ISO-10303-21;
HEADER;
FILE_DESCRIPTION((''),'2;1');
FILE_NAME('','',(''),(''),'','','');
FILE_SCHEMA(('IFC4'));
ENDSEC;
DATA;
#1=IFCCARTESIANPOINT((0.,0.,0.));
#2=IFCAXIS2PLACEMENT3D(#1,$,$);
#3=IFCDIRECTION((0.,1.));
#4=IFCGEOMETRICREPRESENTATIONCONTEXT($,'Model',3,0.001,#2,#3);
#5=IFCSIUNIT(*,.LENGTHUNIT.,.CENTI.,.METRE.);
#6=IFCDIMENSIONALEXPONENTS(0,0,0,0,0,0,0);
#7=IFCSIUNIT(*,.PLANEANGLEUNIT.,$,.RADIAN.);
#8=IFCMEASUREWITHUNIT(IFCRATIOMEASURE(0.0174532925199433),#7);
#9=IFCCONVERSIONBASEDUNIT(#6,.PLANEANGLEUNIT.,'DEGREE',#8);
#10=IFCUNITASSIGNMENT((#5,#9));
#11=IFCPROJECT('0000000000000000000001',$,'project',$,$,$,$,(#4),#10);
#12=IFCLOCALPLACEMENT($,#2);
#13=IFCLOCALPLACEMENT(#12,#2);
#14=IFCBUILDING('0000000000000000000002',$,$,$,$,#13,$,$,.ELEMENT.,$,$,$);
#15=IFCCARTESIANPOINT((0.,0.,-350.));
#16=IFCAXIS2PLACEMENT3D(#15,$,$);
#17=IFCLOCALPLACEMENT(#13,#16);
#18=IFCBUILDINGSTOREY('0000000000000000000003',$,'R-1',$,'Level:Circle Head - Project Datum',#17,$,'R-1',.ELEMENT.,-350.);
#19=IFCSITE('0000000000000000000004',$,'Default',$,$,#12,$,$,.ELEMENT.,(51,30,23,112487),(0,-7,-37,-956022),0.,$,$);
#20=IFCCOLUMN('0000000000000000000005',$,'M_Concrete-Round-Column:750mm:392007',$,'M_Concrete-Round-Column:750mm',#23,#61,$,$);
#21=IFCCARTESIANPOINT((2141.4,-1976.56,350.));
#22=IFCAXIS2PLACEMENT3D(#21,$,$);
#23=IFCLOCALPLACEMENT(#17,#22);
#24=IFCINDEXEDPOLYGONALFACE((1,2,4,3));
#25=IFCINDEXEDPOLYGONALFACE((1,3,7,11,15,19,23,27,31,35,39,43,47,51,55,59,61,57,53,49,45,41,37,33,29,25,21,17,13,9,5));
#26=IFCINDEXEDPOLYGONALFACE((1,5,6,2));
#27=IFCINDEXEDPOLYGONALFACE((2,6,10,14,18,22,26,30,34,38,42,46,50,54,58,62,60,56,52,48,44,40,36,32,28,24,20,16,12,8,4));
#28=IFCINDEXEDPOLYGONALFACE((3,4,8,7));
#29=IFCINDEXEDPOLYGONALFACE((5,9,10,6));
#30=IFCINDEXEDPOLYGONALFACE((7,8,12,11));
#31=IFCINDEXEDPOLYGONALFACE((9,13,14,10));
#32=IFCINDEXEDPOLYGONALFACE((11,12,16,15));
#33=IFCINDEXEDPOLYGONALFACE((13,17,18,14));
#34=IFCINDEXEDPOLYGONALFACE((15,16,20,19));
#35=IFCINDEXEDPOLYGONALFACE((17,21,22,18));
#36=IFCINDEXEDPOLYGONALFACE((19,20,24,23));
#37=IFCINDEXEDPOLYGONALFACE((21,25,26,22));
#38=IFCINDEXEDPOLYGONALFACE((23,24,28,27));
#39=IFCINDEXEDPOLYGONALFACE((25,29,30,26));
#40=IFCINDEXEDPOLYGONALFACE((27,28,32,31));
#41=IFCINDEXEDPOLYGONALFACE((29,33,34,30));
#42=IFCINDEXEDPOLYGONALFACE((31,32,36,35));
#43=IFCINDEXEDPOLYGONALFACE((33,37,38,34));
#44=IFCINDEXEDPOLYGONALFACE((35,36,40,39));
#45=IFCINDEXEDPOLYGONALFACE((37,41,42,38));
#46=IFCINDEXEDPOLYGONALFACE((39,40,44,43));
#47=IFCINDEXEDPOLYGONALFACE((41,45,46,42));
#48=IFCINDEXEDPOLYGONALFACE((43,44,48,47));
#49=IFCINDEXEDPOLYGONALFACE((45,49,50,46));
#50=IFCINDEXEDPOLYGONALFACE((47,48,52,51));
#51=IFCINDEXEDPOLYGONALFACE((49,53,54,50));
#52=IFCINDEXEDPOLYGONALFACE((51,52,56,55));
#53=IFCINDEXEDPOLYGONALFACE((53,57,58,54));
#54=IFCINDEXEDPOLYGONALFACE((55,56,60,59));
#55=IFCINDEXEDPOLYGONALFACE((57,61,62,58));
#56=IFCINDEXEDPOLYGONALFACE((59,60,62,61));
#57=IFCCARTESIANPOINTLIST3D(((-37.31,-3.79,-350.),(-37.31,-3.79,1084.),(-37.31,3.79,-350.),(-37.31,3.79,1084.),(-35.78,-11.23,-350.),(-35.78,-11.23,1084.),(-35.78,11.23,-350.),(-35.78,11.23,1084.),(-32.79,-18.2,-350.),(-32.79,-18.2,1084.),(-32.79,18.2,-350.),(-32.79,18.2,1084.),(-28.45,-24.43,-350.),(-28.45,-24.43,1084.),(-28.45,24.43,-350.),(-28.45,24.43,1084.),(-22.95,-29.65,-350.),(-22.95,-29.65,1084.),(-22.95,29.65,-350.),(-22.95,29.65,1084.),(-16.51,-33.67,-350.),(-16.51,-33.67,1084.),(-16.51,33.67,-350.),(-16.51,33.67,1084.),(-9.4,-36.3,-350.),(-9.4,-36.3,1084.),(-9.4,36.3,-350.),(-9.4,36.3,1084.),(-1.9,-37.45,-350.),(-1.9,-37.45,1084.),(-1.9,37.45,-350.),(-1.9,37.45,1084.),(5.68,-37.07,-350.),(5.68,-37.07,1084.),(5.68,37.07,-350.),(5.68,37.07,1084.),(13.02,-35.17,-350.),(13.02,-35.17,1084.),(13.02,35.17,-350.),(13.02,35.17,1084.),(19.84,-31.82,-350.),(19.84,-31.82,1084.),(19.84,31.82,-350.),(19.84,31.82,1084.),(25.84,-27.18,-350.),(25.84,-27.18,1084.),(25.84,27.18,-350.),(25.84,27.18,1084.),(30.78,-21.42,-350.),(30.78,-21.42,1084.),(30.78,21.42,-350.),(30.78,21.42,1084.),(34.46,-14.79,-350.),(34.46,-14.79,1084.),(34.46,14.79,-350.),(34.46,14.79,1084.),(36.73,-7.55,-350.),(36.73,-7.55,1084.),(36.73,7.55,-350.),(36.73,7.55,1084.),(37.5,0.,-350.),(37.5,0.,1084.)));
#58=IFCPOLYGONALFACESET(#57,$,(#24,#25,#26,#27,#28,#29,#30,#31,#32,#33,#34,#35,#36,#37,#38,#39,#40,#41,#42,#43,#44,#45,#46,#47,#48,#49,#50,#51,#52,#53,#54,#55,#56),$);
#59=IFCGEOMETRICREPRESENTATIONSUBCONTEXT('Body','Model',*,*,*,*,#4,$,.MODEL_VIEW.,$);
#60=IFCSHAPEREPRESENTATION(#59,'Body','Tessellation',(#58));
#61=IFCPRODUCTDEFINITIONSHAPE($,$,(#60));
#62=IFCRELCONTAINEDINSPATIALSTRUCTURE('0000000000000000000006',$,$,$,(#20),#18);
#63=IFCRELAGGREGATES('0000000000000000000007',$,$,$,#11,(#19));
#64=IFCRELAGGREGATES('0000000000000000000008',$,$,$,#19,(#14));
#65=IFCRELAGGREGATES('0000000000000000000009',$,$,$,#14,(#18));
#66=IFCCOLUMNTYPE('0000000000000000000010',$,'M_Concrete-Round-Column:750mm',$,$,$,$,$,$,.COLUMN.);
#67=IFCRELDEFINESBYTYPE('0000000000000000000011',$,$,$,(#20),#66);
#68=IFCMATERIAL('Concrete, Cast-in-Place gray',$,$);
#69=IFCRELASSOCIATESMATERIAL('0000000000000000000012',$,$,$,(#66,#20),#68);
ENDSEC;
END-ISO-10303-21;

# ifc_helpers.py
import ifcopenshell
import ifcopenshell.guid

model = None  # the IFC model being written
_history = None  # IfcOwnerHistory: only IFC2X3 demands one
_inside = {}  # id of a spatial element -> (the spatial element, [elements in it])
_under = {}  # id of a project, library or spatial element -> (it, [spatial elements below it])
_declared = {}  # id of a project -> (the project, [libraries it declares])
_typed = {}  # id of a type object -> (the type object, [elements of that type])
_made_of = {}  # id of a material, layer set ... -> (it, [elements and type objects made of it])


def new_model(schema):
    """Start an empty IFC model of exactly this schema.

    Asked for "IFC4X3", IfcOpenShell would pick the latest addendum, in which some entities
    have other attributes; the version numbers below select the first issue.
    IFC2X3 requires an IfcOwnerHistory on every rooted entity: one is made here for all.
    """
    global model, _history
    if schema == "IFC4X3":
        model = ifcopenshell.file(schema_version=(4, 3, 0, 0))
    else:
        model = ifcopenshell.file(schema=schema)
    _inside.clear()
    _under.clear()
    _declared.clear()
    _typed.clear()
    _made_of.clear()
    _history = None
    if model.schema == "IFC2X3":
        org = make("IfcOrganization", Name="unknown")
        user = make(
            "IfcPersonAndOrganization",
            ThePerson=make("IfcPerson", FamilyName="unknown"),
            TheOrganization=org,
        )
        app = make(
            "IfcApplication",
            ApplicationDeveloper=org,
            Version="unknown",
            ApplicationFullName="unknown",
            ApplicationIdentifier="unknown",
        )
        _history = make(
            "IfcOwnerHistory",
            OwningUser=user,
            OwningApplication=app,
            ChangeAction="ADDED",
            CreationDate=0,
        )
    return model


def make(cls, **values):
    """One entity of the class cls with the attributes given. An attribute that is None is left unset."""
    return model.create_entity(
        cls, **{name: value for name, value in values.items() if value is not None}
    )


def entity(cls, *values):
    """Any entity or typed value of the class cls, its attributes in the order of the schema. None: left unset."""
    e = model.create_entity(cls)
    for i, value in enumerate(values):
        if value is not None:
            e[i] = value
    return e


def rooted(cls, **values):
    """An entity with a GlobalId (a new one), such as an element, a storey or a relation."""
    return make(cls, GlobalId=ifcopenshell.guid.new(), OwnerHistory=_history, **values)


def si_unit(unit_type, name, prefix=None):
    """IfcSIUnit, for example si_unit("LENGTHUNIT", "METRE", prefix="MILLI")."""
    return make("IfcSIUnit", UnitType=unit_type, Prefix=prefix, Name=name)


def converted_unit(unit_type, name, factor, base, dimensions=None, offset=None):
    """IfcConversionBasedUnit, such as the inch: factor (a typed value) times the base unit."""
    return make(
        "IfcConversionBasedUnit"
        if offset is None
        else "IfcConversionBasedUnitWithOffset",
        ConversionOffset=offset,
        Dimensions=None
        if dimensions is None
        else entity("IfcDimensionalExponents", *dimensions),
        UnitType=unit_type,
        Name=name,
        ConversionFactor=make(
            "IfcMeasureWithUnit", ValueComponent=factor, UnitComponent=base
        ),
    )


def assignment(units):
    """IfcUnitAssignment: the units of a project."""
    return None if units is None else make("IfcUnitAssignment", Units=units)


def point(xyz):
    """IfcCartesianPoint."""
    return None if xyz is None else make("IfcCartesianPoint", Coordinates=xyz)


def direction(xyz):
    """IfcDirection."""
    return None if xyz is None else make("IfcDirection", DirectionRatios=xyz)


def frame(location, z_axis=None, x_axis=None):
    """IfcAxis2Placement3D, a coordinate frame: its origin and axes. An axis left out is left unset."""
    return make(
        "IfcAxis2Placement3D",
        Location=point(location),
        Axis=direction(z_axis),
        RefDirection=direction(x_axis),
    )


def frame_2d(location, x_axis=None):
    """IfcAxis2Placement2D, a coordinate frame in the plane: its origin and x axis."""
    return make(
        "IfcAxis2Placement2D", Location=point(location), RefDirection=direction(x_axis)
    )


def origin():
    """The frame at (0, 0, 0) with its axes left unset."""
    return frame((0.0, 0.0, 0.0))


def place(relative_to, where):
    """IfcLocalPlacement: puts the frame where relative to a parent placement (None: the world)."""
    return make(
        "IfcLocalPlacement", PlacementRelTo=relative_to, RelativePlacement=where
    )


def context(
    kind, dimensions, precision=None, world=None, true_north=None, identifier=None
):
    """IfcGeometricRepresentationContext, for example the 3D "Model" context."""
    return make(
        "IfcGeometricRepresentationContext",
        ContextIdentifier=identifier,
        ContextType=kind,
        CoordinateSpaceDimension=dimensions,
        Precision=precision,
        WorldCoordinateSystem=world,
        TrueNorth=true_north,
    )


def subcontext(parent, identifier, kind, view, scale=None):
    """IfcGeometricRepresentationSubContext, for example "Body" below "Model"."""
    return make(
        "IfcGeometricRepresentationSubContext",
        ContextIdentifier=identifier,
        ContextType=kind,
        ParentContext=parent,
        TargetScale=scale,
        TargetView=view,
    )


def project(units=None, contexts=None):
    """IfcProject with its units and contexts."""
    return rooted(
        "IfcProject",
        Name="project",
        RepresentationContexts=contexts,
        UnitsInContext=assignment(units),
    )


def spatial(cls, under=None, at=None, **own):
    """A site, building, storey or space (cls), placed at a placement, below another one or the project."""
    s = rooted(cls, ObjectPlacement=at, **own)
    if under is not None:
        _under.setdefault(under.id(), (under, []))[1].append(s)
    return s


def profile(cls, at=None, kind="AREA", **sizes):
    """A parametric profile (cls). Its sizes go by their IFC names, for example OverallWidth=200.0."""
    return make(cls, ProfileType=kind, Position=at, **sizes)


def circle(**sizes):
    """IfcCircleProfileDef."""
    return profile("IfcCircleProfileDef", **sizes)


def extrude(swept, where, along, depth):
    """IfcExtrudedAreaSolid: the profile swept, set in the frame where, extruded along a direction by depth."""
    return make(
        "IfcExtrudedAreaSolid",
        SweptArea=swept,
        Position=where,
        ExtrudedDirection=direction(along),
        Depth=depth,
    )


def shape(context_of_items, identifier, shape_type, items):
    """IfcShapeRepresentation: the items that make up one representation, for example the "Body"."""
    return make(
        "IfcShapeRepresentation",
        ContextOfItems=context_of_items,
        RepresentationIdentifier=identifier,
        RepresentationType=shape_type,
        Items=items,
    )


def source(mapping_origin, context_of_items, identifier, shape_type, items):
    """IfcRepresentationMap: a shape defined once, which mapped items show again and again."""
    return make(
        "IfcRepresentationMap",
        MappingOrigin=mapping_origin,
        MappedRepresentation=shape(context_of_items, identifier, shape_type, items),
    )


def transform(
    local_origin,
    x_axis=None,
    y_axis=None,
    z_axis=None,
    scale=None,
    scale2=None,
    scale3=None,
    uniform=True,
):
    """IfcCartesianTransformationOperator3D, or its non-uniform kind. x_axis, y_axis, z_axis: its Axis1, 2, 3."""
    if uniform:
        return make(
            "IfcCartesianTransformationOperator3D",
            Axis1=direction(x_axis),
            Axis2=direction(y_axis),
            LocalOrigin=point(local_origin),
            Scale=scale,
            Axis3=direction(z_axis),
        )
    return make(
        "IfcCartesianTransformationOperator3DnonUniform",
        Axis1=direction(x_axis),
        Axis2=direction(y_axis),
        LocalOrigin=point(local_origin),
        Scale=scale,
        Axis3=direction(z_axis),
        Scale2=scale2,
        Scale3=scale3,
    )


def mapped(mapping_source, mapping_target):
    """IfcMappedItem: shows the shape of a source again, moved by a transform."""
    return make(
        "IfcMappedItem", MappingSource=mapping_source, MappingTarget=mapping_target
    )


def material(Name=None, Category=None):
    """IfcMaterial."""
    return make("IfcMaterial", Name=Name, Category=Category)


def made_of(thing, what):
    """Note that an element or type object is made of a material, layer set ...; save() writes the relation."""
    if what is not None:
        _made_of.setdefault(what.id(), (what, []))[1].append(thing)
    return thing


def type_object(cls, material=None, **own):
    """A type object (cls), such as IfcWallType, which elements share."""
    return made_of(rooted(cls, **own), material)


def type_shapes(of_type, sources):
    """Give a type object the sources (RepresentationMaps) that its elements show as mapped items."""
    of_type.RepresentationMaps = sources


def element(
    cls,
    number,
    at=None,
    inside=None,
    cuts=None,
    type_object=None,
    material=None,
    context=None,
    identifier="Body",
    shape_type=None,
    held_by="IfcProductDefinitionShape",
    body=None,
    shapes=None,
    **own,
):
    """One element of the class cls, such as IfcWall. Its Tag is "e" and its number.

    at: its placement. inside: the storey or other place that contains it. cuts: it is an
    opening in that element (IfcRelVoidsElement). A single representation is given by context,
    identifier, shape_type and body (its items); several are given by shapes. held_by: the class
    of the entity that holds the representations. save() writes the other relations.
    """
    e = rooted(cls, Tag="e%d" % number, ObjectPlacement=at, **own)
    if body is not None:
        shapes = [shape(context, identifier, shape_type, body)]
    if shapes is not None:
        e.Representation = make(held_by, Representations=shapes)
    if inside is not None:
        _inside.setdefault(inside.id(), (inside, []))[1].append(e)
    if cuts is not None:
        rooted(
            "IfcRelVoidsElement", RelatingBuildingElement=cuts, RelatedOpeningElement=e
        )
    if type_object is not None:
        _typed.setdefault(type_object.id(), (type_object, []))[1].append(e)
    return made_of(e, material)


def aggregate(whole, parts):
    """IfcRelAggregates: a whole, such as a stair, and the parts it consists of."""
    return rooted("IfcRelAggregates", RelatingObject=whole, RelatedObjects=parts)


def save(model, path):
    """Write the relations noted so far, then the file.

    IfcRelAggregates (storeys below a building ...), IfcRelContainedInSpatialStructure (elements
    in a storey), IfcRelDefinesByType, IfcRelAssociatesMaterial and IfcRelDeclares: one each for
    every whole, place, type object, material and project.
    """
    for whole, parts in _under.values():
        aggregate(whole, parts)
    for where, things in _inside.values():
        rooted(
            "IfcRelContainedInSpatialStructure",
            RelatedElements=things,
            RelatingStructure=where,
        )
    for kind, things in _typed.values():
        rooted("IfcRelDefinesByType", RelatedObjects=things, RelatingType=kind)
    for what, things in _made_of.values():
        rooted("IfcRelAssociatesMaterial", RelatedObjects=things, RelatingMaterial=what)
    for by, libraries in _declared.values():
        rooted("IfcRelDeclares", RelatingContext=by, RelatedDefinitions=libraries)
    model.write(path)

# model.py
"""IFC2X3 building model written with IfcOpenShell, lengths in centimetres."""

from ifc_helpers import new_model, entity, si_unit, converted_unit, direction, frame, frame_2d, origin, place, context, subcontext, project, spatial, circle, extrude, source, transform, mapped, material, type_object, type_shapes, element, save


model = new_model("IFC2X3")

# Units and contexts
model_context = context("Model", 3, precision=0.001, world=origin(), true_north=direction((0.0, 1.0)))
body_context = subcontext(model_context, "Body", "Model", "MODEL_VIEW")
ifc_project = project(units=[si_unit("LENGTHUNIT", "METRE", prefix="CENTI"), converted_unit("PLANEANGLEUNIT", "DEGREE", entity("IfcRatioMeasure", 0.0174532925199433), si_unit("PLANEANGLEUNIT", "RADIAN"), dimensions=[0, 0, 0, 0, 0, 0, 0])], contexts=[model_context])

# Site, building, storey
site_placement = place(None, origin())
site = spatial("IfcSite", under=ifc_project, at=site_placement, Name="Default", CompositionType="ELEMENT", RefLatitude=(51, 30, 23, 112487), RefLongitude=(0, -7, -37, -956022), RefElevation=0.0)
building_placement = place(site_placement, origin())
building = spatial("IfcBuilding", under=site, at=building_placement, CompositionType="ELEMENT")
storey_placement = place(building_placement, frame((0.0, 0.0, -350.0)))
storey = spatial("IfcBuildingStorey", under=building, at=storey_placement, Name="R-1", ObjectType="Level:Circle Head - Project Datum", LongName="R-1", CompositionType="ELEMENT", Elevation=-350.0)

# Column
ifc_material_1 = material(Name="Concrete, Cast-in-Place gray")
column_type_1 = type_object("IfcColumnType", Name="M_Concrete-Round-Column:750mm", PredefinedType="COLUMN", material=ifc_material_1)
shared_shape_1 = source(origin(), body_context, "Body", "SweptSolid", [
    extrude(circle(Radius=37.5, at=frame_2d((0.0, 0.0), x_axis=(1.0, 0.0))), frame((0.0, 0.0, -350.0)), (0.0, 0.0, 1.0), 1434.0),
])
type_shapes(column_type_1, [shared_shape_1])
column_placement = place(storey_placement, frame((2141.4, -1976.56, 350.0)))
element("IfcColumn", 1, at=column_placement, inside=storey, type_object=column_type_1, material=ifc_material_1, Name="M_Concrete-Round-Column:750mm:392007", ObjectType="M_Concrete-Round-Column:750mm", context=body_context, shape_type="MappedRepresentation", body=[
    mapped(shared_shape_1, transform((0.0, 0.0, 0.0), scale=1.0)),
])

save(model, "model.ifc")
